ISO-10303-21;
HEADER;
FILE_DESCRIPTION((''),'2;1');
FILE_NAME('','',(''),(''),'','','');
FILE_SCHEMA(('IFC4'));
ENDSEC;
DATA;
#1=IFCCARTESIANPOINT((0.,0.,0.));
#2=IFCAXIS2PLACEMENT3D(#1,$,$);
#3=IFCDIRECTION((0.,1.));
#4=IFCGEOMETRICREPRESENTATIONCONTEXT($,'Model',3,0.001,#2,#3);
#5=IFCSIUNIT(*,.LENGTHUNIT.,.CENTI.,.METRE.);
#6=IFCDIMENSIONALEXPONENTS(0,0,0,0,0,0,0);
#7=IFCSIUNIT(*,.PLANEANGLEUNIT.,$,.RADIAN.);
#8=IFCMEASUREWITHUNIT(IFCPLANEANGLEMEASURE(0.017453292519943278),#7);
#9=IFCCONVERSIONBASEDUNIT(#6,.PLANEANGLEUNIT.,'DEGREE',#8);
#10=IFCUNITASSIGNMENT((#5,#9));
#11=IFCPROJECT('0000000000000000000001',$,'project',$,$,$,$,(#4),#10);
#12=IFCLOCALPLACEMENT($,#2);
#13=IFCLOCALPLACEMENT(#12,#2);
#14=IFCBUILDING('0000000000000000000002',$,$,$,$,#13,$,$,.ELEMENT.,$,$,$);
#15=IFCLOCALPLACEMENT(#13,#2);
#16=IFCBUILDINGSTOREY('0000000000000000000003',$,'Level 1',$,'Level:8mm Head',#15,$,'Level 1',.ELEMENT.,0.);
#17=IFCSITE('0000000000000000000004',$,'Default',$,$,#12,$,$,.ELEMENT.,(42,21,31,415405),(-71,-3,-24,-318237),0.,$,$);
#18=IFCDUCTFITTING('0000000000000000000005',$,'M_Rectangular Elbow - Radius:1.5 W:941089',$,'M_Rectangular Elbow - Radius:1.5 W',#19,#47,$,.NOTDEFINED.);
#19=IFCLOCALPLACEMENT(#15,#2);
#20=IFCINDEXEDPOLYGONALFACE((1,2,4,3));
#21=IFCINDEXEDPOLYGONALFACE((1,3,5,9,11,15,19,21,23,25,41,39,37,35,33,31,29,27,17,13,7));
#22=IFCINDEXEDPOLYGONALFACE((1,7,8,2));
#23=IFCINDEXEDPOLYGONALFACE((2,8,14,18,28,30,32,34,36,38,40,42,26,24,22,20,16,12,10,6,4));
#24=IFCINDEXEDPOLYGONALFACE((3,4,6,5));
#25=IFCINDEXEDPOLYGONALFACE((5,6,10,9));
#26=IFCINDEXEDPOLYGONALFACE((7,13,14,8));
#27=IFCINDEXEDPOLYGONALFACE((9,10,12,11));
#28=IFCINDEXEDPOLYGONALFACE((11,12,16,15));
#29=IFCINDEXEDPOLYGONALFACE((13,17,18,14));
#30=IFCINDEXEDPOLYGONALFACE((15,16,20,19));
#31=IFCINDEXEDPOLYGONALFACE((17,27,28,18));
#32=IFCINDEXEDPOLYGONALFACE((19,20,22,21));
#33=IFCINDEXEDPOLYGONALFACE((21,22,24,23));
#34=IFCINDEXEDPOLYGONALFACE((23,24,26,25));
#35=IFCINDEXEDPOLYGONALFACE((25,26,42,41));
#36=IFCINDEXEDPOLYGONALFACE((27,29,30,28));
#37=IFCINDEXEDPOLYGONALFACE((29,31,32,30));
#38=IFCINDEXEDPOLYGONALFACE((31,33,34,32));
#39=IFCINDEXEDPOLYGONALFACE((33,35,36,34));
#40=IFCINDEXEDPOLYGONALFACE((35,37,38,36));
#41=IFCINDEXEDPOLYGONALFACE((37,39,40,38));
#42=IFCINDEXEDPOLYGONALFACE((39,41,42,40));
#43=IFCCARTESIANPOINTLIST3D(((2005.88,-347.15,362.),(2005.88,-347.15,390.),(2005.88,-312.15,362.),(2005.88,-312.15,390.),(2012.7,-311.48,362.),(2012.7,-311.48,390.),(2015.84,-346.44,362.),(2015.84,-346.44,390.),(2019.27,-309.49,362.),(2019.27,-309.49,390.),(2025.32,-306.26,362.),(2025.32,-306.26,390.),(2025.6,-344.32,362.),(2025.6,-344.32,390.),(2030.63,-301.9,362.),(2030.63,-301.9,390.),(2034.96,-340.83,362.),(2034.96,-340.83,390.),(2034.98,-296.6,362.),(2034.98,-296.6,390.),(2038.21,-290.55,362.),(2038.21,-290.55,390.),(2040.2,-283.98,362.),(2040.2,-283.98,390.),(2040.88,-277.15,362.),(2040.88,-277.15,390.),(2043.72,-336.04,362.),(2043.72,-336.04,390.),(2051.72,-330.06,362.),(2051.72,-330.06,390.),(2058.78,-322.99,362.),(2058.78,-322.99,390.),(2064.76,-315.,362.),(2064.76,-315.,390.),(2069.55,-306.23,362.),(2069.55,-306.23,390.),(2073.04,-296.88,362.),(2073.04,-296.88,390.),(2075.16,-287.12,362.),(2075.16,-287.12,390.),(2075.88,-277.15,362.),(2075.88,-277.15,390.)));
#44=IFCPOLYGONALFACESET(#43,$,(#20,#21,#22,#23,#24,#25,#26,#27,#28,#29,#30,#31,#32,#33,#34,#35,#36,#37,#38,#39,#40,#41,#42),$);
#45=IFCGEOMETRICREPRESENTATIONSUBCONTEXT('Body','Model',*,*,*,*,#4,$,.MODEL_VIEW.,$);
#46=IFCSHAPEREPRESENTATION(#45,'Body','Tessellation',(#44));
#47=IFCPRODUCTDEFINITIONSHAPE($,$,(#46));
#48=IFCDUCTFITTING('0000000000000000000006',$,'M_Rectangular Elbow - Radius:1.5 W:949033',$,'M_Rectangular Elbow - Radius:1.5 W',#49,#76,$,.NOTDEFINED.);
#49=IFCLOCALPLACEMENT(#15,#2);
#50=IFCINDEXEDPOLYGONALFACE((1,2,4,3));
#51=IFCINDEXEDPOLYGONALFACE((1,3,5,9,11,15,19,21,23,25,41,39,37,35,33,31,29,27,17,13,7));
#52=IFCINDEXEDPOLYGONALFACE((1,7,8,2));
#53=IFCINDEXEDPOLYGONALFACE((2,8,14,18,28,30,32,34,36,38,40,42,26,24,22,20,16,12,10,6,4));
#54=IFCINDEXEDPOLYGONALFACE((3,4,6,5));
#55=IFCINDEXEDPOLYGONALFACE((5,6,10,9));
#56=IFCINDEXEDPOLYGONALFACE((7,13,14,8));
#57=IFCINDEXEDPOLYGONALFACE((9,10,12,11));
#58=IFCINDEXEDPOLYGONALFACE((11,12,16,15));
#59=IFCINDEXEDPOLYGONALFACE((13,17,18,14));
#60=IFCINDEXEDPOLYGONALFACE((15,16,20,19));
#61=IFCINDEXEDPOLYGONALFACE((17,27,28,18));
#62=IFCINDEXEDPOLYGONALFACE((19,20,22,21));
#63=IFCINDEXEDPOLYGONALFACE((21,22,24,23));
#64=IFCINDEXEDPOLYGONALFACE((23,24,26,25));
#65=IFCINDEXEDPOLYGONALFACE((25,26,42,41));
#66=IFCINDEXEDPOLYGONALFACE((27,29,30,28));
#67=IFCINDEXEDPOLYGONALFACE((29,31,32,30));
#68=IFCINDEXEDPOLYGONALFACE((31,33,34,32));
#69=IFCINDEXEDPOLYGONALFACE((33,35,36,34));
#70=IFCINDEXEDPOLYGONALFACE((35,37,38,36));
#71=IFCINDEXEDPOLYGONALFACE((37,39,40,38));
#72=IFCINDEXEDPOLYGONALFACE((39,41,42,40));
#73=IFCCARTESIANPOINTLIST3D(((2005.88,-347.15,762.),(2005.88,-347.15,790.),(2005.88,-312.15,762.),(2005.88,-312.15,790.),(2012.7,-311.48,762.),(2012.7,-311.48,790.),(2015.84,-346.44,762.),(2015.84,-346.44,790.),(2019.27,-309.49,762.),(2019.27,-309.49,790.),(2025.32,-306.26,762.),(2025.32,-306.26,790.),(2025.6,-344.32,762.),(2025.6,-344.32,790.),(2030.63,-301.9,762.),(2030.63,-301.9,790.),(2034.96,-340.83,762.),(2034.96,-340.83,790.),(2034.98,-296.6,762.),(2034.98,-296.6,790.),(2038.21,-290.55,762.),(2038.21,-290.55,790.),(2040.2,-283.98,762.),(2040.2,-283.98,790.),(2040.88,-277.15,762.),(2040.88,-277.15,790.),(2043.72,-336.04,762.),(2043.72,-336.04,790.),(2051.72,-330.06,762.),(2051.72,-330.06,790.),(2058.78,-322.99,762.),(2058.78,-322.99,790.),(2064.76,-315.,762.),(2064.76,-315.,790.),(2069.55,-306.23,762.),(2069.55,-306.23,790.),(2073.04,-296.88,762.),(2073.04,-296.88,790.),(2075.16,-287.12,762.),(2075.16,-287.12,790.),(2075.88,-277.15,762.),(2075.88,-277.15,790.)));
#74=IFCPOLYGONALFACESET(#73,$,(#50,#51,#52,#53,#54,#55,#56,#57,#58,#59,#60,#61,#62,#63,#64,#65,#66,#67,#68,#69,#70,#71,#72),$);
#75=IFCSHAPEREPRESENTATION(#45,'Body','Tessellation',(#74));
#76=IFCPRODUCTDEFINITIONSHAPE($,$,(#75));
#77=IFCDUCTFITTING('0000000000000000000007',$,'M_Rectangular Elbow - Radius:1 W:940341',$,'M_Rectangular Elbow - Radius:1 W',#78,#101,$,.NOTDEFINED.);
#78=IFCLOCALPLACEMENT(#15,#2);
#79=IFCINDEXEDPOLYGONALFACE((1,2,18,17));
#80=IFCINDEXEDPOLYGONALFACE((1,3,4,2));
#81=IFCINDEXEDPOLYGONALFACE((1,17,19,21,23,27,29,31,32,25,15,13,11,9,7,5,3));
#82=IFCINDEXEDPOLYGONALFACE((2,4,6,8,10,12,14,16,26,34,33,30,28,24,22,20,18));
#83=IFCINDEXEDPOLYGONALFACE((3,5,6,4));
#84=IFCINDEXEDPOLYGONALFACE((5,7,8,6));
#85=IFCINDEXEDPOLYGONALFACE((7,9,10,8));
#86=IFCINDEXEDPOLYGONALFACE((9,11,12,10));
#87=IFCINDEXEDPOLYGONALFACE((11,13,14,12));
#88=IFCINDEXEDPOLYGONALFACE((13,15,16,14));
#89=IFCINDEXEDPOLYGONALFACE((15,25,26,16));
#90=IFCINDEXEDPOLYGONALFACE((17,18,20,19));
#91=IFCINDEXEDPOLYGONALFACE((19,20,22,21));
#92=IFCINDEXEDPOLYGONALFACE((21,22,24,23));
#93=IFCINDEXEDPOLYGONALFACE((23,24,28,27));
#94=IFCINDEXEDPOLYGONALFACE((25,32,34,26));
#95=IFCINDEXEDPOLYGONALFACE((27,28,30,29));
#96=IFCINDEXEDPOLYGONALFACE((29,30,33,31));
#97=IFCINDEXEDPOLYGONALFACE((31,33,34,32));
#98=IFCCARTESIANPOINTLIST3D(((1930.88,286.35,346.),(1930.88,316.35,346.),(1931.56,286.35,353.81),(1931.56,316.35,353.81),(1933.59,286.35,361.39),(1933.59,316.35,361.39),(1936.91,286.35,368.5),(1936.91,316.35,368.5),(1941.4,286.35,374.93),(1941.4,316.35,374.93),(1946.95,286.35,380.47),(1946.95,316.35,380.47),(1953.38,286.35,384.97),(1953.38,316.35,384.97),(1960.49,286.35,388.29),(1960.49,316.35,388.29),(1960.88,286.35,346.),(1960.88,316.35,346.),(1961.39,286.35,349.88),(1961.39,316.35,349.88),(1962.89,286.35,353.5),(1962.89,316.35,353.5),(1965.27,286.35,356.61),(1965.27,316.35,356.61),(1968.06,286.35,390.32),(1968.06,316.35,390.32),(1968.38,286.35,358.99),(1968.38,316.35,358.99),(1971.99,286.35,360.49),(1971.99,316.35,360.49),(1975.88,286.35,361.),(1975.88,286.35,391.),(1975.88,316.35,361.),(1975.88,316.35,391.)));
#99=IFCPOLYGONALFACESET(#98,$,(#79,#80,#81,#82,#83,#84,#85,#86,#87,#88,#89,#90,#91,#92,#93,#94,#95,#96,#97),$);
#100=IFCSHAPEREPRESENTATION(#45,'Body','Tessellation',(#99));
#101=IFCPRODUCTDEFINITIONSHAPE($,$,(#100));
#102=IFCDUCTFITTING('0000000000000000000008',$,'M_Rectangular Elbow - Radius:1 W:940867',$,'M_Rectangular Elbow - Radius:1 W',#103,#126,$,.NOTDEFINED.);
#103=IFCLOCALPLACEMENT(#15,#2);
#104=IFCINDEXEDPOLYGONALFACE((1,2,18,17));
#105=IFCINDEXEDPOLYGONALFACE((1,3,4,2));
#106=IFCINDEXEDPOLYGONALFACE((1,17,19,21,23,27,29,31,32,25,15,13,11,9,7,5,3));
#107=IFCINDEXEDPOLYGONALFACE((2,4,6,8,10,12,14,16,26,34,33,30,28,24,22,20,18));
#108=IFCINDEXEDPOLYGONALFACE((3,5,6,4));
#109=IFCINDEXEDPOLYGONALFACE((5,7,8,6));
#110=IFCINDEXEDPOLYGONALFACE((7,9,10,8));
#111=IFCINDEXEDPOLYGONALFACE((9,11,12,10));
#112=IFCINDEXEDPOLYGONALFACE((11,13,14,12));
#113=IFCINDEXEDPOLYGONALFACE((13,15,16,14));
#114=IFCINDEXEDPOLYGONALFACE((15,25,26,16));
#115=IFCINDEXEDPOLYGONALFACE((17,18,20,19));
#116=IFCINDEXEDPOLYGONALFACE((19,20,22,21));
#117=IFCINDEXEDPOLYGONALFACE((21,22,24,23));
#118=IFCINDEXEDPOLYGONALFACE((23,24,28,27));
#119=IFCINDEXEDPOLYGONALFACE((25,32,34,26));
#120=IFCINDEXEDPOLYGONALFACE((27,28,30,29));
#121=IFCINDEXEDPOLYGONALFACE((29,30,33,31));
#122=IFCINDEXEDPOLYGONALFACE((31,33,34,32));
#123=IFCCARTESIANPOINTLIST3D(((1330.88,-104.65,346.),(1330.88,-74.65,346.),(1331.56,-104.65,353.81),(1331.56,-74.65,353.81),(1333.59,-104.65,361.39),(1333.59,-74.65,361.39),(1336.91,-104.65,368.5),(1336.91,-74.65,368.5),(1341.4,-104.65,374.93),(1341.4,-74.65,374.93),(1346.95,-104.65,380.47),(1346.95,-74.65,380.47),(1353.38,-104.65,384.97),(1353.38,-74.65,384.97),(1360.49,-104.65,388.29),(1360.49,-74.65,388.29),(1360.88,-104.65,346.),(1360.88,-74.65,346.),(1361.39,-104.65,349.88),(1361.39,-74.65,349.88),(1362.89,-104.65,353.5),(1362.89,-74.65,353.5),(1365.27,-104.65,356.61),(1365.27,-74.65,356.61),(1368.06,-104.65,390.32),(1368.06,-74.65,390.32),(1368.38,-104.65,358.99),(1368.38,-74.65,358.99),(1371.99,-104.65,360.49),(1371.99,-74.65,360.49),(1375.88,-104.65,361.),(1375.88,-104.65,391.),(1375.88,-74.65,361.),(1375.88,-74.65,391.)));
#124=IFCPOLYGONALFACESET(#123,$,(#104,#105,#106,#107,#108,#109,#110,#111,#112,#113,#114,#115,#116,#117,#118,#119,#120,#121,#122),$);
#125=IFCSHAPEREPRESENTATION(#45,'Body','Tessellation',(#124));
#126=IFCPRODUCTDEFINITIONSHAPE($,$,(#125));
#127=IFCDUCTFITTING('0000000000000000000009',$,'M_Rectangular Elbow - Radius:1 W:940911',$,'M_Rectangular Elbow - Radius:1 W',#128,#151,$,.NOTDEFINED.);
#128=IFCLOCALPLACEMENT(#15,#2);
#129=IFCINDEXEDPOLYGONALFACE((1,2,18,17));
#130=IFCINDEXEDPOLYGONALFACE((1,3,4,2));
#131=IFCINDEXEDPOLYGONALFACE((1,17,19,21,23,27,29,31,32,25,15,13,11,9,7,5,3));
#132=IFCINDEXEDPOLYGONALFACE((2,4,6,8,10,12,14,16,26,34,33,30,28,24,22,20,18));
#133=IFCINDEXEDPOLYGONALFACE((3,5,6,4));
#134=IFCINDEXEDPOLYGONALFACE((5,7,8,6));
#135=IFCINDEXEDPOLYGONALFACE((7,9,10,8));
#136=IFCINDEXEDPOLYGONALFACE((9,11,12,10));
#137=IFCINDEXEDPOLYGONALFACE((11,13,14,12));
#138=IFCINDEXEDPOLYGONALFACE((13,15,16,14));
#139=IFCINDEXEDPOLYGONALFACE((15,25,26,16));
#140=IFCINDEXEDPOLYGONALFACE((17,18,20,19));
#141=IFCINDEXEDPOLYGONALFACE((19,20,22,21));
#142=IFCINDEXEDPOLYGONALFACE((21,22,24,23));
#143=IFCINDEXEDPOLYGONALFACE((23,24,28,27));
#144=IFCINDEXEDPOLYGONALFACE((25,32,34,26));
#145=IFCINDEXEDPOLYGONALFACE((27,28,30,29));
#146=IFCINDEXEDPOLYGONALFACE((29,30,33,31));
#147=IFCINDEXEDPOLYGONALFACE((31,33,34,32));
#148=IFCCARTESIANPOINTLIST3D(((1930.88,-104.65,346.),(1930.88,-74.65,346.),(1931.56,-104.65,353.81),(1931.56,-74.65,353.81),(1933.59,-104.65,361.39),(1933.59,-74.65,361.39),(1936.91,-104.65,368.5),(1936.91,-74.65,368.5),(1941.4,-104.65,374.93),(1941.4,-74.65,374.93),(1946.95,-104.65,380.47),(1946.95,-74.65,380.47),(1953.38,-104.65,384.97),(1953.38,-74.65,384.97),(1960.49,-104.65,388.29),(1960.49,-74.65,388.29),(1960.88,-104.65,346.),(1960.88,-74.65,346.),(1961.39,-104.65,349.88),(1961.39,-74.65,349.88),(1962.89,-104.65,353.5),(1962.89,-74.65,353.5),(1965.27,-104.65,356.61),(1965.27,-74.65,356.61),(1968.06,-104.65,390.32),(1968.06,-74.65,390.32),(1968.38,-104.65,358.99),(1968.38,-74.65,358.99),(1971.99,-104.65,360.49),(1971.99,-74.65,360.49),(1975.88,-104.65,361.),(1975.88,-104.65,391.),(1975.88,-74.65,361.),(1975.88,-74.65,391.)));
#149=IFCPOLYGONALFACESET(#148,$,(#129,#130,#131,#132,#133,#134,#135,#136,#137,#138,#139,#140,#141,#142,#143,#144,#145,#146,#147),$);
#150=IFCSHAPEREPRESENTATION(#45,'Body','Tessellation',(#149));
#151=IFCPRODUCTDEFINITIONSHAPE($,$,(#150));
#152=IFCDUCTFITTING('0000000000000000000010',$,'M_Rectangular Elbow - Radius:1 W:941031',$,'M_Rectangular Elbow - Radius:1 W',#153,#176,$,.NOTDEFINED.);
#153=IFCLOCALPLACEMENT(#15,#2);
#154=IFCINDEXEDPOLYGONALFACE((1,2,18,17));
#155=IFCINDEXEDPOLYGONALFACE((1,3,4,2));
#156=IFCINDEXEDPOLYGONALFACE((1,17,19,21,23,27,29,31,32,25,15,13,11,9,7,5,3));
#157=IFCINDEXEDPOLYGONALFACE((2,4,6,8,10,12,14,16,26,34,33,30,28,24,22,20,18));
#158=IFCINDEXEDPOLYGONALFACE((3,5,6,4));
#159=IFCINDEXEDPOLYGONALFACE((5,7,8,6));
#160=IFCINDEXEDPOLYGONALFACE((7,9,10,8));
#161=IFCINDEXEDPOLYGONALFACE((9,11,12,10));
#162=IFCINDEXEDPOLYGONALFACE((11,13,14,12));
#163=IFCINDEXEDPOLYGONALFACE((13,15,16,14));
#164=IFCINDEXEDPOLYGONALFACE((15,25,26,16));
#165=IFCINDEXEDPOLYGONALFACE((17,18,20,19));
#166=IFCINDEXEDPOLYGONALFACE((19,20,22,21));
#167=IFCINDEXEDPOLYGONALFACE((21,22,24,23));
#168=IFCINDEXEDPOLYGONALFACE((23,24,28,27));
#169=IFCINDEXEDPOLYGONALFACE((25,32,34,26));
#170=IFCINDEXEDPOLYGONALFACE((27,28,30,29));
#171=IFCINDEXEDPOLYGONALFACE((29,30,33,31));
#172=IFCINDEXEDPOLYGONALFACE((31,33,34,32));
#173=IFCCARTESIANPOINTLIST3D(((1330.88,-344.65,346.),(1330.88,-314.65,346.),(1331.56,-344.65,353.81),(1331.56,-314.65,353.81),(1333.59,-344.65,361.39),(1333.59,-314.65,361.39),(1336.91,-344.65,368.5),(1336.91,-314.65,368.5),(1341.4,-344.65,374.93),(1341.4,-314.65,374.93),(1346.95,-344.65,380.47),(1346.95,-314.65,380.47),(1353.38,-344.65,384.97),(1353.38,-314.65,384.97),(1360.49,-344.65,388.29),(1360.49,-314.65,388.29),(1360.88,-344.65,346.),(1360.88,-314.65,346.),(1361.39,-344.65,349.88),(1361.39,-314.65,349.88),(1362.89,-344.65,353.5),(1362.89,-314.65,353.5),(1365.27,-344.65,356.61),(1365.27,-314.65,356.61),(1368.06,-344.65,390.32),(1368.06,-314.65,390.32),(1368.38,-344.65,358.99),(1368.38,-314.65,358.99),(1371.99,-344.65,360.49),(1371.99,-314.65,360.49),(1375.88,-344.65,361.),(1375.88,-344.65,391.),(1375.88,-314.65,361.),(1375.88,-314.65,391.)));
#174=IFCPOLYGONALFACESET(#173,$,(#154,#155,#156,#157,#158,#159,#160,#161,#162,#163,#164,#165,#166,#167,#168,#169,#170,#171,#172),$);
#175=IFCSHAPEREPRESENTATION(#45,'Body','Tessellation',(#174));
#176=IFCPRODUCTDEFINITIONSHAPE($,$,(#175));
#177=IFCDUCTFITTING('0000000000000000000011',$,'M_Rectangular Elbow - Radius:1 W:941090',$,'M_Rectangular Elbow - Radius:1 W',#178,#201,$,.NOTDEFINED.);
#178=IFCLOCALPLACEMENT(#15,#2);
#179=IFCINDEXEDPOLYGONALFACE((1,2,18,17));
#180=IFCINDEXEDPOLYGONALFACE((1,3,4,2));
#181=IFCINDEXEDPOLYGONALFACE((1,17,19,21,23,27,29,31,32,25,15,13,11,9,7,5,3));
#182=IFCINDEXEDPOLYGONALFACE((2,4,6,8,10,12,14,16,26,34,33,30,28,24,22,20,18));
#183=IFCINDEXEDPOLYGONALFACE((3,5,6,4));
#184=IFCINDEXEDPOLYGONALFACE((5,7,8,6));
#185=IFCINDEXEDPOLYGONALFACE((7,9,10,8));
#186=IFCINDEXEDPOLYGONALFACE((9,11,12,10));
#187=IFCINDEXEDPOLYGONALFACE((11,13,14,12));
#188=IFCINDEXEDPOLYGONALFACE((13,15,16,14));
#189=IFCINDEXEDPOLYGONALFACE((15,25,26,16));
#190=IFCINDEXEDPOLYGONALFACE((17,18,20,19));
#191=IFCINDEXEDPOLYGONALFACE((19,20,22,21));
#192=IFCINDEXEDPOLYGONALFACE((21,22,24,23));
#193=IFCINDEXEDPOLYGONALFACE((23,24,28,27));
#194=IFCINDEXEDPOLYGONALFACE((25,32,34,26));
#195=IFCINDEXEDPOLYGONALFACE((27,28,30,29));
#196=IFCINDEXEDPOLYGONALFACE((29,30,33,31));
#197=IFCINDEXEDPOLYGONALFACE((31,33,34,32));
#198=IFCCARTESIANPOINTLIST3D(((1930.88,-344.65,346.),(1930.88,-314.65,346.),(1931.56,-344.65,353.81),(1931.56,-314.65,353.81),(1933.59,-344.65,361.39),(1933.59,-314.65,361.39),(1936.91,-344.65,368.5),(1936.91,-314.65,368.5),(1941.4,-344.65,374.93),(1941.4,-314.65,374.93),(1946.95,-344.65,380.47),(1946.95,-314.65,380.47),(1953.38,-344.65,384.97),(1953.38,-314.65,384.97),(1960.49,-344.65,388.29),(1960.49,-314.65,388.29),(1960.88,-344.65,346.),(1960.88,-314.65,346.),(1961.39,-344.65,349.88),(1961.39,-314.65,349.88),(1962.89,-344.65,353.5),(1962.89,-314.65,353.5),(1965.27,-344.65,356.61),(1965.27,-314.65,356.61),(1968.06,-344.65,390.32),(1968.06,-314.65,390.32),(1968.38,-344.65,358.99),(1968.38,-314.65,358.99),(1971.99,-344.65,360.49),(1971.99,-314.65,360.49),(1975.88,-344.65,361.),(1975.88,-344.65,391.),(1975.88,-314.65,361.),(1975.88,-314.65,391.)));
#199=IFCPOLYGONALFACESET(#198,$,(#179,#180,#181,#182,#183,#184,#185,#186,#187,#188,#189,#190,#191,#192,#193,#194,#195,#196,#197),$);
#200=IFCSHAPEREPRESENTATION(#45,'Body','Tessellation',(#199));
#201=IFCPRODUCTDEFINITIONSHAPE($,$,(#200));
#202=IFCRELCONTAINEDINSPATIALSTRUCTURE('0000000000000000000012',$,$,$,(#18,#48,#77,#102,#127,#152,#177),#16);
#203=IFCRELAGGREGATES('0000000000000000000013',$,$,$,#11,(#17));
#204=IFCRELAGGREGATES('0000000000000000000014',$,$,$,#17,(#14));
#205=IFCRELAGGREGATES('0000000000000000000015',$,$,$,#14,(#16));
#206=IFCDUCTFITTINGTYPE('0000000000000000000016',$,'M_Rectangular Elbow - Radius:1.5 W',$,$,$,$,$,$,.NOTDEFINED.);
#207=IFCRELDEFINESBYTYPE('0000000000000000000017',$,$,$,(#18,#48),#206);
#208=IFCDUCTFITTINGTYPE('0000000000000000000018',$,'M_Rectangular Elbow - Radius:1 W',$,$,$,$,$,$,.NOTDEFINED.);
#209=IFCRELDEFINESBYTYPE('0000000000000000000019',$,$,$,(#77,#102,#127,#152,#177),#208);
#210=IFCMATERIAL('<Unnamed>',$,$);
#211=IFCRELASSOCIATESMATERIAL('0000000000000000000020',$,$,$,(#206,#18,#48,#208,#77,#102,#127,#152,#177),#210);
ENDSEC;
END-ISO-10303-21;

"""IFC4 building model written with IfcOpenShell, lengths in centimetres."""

from ifc_helpers import new_model, entity, si_unit, converted_unit, direction, frame, origin, place, context, subcontext, project, spatial, line, arc, indexed_curve, outline, extrude, source, transform, mapped, material, type_object, type_shapes, element, save


model = new_model("IFC4")

# Units and contexts
model_context = context("Model", 3, precision=0.001, world=origin(), true_north=direction((0.0, 1.0)))
body_context = subcontext(model_context, "Body", "Model", "MODEL_VIEW")
ifc_project = project(units=[si_unit("LENGTHUNIT", "METRE", prefix="CENTI"), converted_unit("PLANEANGLEUNIT", "DEGREE", entity("IfcPlaneAngleMeasure", 0.017453292519943278), si_unit("PLANEANGLEUNIT", "RADIAN"), dimensions=[0, 0, 0, 0, 0, 0, 0])], contexts=[model_context])

# Site, building, storey
site_placement = place(None, origin())
site = spatial("IfcSite", under=ifc_project, at=site_placement, Name="Default", CompositionType="ELEMENT", RefLatitude=(42, 21, 31, 415405), RefLongitude=(-71, -3, -24, -318237), RefElevation=0.0)
building_placement = place(site_placement, origin())
building = spatial("IfcBuilding", under=site, at=building_placement, CompositionType="ELEMENT")
storey_placement = place(building_placement, origin())
storey = spatial("IfcBuildingStorey", under=building, at=storey_placement, Name="Level 1", ObjectType="Level:8mm Head", LongName="Level 1", CompositionType="ELEMENT", Elevation=0.0)

# Duct fittings
ifc_material = material(Name="<Unnamed>")
duct_fitting_type_1 = type_object("IfcDuctFittingType", Name="M_Rectangular Elbow - Radius:1.5 W", PredefinedType="NOTDEFINED", material=ifc_material)
shared_shape_1 = source(origin(), body_context, "Body", "SweptSolid", [
    extrude(outline(indexed_curve([(-43.75, -26.25), (-8.75, -26.25), (1.5, -1.5), (26.25, 8.75), (26.25, 43.75), (-23.25, 23.25)], segments=[line(1, 2), arc(2, 3, 4), line(4, 5), arc(5, 6, 1)], self_intersect=False)), frame((-26.25, 26.25, -14.0), z_axis=(0.0, 0.0, 1.0), x_axis=(-1.0, 0.0, 0.0)), (0.0, 0.0, 1.0), 28.0),
])
type_shapes(duct_fitting_type_1, [shared_shape_1])
for number, where, name in (
    (1, (2058.38, -329.65, 376.0), "M_Rectangular Elbow - Radius:1.5 W:941089"),
    (2, (2058.38, -329.65, 776.0), "M_Rectangular Elbow - Radius:1.5 W:949033"),
):
    element("IfcDuctFitting", number, at=place(storey_placement, frame(where)), inside=storey, type_object=duct_fitting_type_1, material=ifc_material, Name=name, ObjectType="M_Rectangular Elbow - Radius:1.5 W", PredefinedType="NOTDEFINED", context=body_context, shape_type="MappedRepresentation", body=[
        mapped(shared_shape_1, transform((0.0, 0.0, 0.0), scale=1.0)),
    ])
duct_fitting_type_2 = type_object("IfcDuctFittingType", Name="M_Rectangular Elbow - Radius:1 W", PredefinedType="NOTDEFINED", material=ifc_material)
shared_shape_2 = source(origin(), body_context, "Body", "SweptSolid", [
    extrude(outline(indexed_curve([(-30.0, -15.0), (0.0, -15.0), (4.39, -4.39), (15.0, 0.0), (15.0, 30.0), (-16.82, 16.82)], segments=[line(1, 2), arc(2, 3, 4), line(4, 5), arc(5, 6, 1)], self_intersect=False)), frame((-15.0, 15.0, -15.0), z_axis=(0.0, 0.0, 1.0), x_axis=(-1.0, 0.0, 0.0)), (0.0, 0.0, 1.0), 30.0),
])
type_shapes(duct_fitting_type_2, [shared_shape_2])
for number, where, z_axis, x_axis, name in (
    (3, (1945.88, 301.35, 376.0), (0.0, -1.0, 0.0), (-1.0, 0.0, 0.0), "M_Rectangular Elbow - Radius:1 W:940341"),
    (4, (1345.88, -89.65, 376.0), (0.0, 1.0, 0.0), (0.0, 0.0, 1.0), "M_Rectangular Elbow - Radius:1 W:940867"),
    (5, (1945.88, -89.65, 376.0), (0.0, 1.0, 0.0), (0.0, 0.0, 1.0), "M_Rectangular Elbow - Radius:1 W:940911"),
    (6, (1345.88, -329.65, 376.0), (0.0, 1.0, 0.0), (0.0, 0.0, 1.0), "M_Rectangular Elbow - Radius:1 W:941031"),
    (7, (1945.88, -329.65, 376.0), (0.0, 1.0, 0.0), (0.0, 0.0, 1.0), "M_Rectangular Elbow - Radius:1 W:941090"),
):
    element("IfcDuctFitting", number, at=place(storey_placement, frame(where, z_axis=z_axis, x_axis=x_axis)), inside=storey, type_object=duct_fitting_type_2, material=ifc_material, Name=name, ObjectType="M_Rectangular Elbow - Radius:1 W", PredefinedType="NOTDEFINED", context=body_context, shape_type="MappedRepresentation", body=[
        mapped(shared_shape_2, transform((0.0, 0.0, 0.0), scale=1.0)),
    ])

save(model, "model.ifc")
